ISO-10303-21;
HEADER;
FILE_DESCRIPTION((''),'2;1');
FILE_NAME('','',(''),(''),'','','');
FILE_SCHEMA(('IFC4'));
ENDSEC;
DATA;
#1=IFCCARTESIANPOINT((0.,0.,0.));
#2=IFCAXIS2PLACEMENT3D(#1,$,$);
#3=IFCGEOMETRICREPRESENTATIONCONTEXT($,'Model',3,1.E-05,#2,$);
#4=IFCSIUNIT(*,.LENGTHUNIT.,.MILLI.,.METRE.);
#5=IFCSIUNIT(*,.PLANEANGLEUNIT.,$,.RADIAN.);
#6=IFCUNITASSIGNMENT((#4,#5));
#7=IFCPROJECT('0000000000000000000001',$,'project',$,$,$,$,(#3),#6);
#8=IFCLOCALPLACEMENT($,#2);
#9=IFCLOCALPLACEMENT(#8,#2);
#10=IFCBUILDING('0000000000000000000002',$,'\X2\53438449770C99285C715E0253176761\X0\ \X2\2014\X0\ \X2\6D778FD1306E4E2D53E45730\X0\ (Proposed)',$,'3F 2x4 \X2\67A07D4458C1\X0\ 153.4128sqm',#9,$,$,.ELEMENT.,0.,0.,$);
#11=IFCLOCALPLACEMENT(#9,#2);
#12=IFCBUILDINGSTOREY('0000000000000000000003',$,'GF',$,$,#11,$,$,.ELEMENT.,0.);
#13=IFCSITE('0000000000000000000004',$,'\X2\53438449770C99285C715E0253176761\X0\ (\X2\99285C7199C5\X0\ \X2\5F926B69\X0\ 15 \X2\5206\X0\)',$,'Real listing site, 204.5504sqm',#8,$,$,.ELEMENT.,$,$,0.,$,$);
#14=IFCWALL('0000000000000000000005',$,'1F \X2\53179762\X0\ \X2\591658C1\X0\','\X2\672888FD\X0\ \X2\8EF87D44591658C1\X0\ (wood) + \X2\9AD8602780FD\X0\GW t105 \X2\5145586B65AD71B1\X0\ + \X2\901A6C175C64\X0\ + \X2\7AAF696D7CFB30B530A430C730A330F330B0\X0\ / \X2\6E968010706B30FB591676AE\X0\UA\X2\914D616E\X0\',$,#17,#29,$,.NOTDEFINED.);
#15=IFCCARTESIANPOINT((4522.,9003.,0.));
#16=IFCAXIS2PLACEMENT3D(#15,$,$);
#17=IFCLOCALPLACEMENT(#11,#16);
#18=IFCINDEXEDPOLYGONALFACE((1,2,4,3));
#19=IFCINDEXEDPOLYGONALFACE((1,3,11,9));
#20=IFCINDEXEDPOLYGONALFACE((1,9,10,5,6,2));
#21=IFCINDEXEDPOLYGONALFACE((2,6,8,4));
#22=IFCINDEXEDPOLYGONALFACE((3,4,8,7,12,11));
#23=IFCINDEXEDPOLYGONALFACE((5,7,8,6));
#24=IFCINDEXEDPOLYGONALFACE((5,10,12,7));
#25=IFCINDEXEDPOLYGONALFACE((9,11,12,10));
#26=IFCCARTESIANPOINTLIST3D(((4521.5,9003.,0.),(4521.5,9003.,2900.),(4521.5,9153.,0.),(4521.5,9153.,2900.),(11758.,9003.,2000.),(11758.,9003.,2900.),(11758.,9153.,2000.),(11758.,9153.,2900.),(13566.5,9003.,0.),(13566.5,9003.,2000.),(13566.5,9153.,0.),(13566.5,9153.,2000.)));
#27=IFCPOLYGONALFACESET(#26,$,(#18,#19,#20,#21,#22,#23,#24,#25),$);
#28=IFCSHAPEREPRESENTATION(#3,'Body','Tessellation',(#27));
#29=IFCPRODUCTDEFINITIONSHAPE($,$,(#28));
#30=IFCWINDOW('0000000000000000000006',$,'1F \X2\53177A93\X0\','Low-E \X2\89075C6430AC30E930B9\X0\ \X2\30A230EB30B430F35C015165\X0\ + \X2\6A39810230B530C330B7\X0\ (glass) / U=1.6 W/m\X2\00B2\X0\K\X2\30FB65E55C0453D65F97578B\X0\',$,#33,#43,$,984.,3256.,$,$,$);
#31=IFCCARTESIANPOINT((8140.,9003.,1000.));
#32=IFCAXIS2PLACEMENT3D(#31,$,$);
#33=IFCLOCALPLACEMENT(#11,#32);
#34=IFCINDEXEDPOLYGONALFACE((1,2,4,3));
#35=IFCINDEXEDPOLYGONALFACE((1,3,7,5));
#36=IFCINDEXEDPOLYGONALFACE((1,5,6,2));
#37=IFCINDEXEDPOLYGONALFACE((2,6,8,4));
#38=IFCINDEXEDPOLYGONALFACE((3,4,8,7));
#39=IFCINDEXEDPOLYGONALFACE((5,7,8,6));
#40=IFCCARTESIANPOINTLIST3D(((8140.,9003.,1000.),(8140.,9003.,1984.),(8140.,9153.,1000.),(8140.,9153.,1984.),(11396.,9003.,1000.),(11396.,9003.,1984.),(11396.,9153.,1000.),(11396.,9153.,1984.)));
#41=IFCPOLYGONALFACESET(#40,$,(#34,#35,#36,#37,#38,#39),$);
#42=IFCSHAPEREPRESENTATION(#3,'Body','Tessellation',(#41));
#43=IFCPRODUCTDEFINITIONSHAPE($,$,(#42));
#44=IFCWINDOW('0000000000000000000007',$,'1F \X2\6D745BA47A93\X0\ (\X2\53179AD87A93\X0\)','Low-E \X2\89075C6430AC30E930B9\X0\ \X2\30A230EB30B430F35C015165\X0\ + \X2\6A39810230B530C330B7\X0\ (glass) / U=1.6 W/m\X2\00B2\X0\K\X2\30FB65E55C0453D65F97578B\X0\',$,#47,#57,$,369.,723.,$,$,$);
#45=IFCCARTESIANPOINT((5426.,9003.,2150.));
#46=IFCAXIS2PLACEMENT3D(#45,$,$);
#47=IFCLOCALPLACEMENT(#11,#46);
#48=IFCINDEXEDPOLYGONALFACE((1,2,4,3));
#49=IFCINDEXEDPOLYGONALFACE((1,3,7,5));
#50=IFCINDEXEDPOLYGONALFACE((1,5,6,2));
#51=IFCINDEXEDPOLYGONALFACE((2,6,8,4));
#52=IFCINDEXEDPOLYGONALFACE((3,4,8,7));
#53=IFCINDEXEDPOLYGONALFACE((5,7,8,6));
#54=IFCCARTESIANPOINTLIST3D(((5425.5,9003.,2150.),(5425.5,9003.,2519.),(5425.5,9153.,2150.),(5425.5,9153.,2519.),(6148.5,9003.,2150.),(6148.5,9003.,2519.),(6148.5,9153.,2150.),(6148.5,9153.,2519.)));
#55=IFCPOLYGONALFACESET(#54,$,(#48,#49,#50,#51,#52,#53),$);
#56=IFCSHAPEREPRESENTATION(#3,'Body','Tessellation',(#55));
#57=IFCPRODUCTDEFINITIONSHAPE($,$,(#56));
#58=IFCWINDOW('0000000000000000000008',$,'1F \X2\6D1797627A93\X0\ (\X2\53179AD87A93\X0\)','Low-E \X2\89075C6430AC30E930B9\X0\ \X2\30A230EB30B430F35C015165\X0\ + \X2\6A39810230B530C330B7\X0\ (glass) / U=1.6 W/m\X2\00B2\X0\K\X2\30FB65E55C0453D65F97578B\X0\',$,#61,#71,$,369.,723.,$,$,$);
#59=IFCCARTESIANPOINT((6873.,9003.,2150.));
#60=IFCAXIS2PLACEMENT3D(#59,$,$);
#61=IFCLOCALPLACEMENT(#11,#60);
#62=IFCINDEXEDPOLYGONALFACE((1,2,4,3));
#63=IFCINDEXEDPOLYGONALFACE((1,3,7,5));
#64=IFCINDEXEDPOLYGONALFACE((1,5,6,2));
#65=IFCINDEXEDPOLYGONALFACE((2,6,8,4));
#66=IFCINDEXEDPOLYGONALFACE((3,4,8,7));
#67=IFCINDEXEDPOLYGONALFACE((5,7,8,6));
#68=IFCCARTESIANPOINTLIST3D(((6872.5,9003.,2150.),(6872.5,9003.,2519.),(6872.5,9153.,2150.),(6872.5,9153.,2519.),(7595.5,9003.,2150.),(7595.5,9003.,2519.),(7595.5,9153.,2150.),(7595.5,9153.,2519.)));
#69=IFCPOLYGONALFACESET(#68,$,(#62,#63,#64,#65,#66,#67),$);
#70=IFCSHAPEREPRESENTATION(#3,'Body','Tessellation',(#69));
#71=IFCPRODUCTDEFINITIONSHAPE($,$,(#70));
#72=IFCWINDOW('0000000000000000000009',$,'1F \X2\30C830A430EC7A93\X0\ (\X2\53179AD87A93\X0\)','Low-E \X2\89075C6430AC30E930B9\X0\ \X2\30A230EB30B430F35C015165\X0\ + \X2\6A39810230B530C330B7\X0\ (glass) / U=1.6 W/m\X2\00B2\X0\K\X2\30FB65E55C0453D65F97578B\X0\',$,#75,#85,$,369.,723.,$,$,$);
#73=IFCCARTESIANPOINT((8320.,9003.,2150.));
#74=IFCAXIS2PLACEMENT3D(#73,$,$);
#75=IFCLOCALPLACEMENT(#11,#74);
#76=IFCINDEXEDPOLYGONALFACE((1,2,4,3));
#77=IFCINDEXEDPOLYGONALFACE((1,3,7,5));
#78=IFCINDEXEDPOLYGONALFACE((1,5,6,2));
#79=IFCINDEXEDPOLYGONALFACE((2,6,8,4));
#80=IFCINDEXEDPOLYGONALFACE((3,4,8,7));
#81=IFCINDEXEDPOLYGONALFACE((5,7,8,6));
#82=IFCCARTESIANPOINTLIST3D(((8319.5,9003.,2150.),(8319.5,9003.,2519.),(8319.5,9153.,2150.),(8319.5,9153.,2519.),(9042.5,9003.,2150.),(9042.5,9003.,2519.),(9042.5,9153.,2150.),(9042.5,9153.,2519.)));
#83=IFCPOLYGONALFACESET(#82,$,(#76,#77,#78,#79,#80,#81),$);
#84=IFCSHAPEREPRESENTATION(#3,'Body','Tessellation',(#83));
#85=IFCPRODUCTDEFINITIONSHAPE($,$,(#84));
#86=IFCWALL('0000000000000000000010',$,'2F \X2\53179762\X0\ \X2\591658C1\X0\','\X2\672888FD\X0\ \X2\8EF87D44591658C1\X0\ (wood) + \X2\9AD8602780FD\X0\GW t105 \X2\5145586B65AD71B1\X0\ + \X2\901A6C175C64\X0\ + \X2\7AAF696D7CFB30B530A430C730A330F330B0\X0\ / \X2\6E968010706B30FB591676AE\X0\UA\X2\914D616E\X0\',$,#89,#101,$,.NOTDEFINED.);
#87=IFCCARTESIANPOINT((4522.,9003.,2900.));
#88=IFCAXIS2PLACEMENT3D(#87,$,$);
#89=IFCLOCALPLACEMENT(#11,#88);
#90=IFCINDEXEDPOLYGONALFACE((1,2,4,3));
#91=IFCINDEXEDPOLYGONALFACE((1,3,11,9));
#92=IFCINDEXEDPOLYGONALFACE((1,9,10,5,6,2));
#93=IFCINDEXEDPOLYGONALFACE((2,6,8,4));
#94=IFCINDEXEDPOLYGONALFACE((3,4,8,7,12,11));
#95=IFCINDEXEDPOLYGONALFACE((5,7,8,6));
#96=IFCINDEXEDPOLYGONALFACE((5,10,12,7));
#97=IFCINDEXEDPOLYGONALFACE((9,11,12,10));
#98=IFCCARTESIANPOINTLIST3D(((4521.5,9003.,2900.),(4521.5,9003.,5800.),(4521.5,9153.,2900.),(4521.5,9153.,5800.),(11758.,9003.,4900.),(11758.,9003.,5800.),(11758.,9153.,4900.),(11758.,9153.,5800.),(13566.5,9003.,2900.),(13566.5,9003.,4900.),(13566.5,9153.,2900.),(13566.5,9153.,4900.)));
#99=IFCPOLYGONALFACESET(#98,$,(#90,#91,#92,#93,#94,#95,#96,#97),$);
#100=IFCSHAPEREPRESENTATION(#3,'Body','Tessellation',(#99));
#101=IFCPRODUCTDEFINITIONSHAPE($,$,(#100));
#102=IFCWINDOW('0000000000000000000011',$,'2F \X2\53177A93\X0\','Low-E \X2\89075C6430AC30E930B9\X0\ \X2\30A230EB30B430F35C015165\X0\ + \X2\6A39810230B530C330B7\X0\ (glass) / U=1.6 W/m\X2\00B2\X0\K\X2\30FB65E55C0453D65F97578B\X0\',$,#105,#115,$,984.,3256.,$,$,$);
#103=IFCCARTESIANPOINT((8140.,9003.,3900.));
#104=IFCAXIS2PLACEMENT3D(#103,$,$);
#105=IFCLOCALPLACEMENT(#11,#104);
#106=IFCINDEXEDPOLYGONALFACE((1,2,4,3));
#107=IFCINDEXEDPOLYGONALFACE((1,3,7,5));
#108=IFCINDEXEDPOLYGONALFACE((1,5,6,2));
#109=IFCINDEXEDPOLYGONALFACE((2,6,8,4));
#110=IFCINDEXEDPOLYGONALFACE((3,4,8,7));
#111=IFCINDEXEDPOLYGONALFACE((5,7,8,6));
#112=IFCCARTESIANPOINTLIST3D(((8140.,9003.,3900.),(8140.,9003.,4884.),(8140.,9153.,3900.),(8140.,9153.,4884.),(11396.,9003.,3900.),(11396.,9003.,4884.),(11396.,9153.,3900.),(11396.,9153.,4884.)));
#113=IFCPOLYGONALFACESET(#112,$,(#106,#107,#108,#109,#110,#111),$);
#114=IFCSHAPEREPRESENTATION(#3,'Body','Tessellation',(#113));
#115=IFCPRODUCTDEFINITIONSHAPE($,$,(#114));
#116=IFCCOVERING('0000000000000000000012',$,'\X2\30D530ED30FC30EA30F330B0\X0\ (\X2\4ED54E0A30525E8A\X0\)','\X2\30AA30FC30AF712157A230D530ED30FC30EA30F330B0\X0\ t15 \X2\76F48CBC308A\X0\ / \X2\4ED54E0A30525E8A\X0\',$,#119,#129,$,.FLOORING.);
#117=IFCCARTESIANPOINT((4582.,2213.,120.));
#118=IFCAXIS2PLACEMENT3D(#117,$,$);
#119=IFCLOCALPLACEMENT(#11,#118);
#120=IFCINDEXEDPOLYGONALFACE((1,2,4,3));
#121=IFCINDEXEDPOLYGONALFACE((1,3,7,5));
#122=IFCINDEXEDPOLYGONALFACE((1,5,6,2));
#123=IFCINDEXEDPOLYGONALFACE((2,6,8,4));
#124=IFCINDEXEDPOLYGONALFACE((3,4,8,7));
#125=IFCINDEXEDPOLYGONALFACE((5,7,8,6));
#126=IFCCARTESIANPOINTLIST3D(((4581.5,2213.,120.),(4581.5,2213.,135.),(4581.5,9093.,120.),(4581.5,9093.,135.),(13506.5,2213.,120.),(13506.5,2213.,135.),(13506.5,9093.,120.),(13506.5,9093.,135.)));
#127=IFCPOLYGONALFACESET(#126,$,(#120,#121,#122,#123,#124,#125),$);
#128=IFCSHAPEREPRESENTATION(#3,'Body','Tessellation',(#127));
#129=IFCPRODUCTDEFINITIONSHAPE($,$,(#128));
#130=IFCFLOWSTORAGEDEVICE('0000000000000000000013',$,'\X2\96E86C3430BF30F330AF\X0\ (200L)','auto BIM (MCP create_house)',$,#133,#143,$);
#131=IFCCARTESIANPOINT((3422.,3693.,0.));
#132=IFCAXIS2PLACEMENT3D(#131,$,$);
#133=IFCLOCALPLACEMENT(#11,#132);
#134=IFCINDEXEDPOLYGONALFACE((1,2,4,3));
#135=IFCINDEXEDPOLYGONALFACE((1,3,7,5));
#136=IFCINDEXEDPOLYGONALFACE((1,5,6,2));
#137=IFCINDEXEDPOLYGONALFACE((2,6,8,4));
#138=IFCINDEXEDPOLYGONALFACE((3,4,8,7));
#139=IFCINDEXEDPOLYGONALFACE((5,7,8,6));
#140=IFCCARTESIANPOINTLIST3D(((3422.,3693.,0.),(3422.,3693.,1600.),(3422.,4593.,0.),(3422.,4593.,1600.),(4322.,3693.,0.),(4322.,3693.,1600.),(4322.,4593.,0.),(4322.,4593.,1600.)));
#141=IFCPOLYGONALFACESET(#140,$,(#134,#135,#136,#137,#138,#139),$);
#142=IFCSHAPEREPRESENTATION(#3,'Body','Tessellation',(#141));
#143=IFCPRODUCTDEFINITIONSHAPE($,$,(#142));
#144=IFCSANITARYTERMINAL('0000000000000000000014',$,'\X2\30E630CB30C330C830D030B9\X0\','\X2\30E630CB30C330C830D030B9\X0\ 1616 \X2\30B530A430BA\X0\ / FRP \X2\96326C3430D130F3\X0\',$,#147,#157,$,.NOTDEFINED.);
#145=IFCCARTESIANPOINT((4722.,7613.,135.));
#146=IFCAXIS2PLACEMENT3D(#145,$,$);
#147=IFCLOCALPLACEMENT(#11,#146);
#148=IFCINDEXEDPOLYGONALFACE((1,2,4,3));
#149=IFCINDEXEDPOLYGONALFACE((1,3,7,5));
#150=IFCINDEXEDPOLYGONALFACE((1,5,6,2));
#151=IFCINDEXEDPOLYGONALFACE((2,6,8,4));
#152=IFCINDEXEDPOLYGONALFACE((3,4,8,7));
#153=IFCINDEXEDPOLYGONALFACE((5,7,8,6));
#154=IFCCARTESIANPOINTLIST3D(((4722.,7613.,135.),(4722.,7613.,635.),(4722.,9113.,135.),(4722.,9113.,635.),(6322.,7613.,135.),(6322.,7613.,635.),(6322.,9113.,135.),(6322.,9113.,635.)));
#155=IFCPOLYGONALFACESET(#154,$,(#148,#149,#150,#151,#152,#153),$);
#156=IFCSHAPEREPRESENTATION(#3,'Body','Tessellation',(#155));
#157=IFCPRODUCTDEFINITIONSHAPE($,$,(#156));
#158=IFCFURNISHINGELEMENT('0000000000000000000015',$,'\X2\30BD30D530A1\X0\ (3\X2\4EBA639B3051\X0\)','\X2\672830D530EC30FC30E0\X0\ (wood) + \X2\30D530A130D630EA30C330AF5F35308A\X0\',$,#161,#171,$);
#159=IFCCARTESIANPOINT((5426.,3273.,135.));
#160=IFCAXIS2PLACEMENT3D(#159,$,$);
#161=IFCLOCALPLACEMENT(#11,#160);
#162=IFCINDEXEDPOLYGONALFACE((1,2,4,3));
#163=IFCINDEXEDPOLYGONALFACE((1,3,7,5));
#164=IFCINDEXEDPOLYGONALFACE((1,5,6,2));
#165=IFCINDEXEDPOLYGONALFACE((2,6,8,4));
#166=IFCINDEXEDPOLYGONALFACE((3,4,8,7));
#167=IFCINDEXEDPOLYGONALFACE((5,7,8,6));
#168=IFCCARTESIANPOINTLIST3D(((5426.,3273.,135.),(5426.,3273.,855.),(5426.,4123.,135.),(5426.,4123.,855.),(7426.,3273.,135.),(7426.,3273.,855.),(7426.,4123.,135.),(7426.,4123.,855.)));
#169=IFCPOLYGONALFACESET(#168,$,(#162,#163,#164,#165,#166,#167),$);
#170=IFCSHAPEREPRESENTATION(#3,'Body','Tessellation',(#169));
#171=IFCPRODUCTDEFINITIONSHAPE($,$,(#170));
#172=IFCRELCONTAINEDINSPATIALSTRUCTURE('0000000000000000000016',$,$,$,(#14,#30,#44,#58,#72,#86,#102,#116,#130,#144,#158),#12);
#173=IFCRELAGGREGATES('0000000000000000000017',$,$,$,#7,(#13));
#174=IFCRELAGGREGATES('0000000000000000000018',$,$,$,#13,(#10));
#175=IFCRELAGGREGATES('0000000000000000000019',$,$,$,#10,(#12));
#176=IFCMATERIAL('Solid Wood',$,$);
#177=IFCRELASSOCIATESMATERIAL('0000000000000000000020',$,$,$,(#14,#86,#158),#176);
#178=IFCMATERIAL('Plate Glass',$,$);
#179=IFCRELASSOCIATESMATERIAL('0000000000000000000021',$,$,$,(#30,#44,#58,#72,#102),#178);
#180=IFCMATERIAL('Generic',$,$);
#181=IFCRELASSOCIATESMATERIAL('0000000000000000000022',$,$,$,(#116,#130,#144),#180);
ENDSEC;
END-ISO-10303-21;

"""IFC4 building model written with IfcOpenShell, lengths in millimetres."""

from ifc_helpers import new_model, si_unit, frame, frame_2d, origin, place, context, project, spatial, rectangle, extrude, material, element, fill, save


model = new_model("IFC4")

# Units and contexts
model_context = context("Model", 3, precision=1e-05, world=origin())
ifc_project = project(units=[si_unit("LENGTHUNIT", "METRE", prefix="MILLI"), si_unit("PLANEANGLEUNIT", "RADIAN")], contexts=[model_context])

# Site, building, storey
site_placement = place(None, origin())
site = spatial("IfcSite", under=ifc_project, at=site_placement, Name="千葉県館山市北条 (館山駅 徒歩 15 分)", ObjectType="Real listing site, 204.5504sqm", CompositionType="ELEMENT", RefElevation=0.0)
building_placement = place(site_placement, origin())
building = spatial("IfcBuilding", under=site, at=building_placement, Name="千葉県館山市北条 — 海近の中古地 (Proposed)", ObjectType="3F 2x4 枠組壁 153.4128sqm", CompositionType="ELEMENT", ElevationOfRefHeight=0.0, ElevationOfTerrain=0.0)
storey_placement = place(building_placement, origin())
storey = spatial("IfcBuildingStorey", under=building, at=storey_placement, Name="GF", CompositionType="ELEMENT", Elevation=0.0)

# Wall, openings, windows
ifc_material_1 = material(Name="Solid Wood")
wall_1_placement = place(storey_placement, frame((4522.0, 9003.0, 0.0)))
wall_1 = element("IfcWall", 1, at=wall_1_placement, inside=storey, material=ifc_material_1, Name="1F 北面 外壁", Description="木製 軸組外壁 (wood) + 高性能GW t105 充填断熱 + 通気層 + 窯業系サイディング / 準耐火・外皮UA配慮", PredefinedType="NOTDEFINED", context=model_context, shape_type="SweptSolid", body=[
    extrude(rectangle(XDim=9045.0, YDim=150.0, at=frame_2d((4522.0, 75.0))), frame((4522.0, 9003.0, 0.0)), (0.0, 0.0, 1.0), 2900.0),
])
opening_1_placement = place(storey_placement, frame((8140.0, 9003.0, 1000.0)))
opening_1 = element("IfcOpeningElement", 2, at=opening_1_placement, cuts=wall_1, PredefinedType="NOTDEFINED", context=model_context, shape_type="SweptSolid", body=[
    extrude(rectangle(XDim=3256.0, YDim=150.0, at=frame_2d((1628.0, 75.0))), frame((8140.0, 9003.0, 1000.0)), (0.0, 0.0, 1.0), 984.0),
])
opening_2_placement = place(storey_placement, frame((5426.0, 9003.0, 2150.0)))
opening_2 = element("IfcOpeningElement", 3, at=opening_2_placement, cuts=wall_1, PredefinedType="NOTDEFINED", context=model_context, shape_type="SweptSolid", body=[
    extrude(rectangle(XDim=723.0, YDim=150.0, at=frame_2d((361.0, 75.0))), frame((5426.0, 9003.0, 2150.0)), (0.0, 0.0, 1.0), 369.0),
])
opening_3_placement = place(storey_placement, frame((6873.0, 9003.0, 2150.0)))
opening_3 = element("IfcOpeningElement", 4, at=opening_3_placement, cuts=wall_1, PredefinedType="NOTDEFINED", context=model_context, shape_type="SweptSolid", body=[
    extrude(rectangle(XDim=723.0, YDim=150.0, at=frame_2d((361.0, 75.0))), frame((6873.0, 9003.0, 2150.0)), (0.0, 0.0, 1.0), 369.0),
])
opening_4_placement = place(storey_placement, frame((8320.0, 9003.0, 2150.0)))
opening_4 = element("IfcOpeningElement", 5, at=opening_4_placement, cuts=wall_1, PredefinedType="NOTDEFINED", context=model_context, shape_type="SweptSolid", body=[
    extrude(rectangle(XDim=723.0, YDim=150.0, at=frame_2d((361.0, 75.0))), frame((8320.0, 9003.0, 2150.0)), (0.0, 0.0, 1.0), 369.0),
])
ifc_material_2 = material(Name="Plate Glass")
window_1_placement = place(storey_placement, frame((8140.0, 9003.0, 1000.0)))
window_1 = element("IfcWindow", 6, at=window_1_placement, inside=storey, material=ifc_material_2, Name="1F 北窓", Description="Low-E 複層ガラス アルゴン封入 + 樹脂サッシ (glass) / U=1.6 W/m²K・日射取得型", OverallHeight=984.0, OverallWidth=3256.0, context=model_context, shape_type="SweptSolid", body=[
    extrude(rectangle(XDim=3256.0, YDim=150.0, at=frame_2d((1628.0, 75.0))), frame((8140.0, 9003.0, 1000.0)), (0.0, 0.0, 1.0), 984.0),
])
fill(opening_1, window_1)
window_2_placement = place(storey_placement, frame((5426.0, 9003.0, 2150.0)))
window_2 = element("IfcWindow", 7, at=window_2_placement, inside=storey, material=ifc_material_2, Name="1F 浴室窓 (北高窓)", Description="Low-E 複層ガラス アルゴン封入 + 樹脂サッシ (glass) / U=1.6 W/m²K・日射取得型", OverallHeight=369.0, OverallWidth=723.0, context=model_context, shape_type="SweptSolid", body=[
    extrude(rectangle(XDim=723.0, YDim=150.0, at=frame_2d((361.0, 75.0))), frame((5426.0, 9003.0, 2150.0)), (0.0, 0.0, 1.0), 369.0),
])
fill(opening_2, window_2)
window_3_placement = place(storey_placement, frame((6873.0, 9003.0, 2150.0)))
window_3 = element("IfcWindow", 8, at=window_3_placement, inside=storey, material=ifc_material_2, Name="1F 洗面窓 (北高窓)", Description="Low-E 複層ガラス アルゴン封入 + 樹脂サッシ (glass) / U=1.6 W/m²K・日射取得型", OverallHeight=369.0, OverallWidth=723.0, context=model_context, shape_type="SweptSolid", body=[
    extrude(rectangle(XDim=723.0, YDim=150.0, at=frame_2d((361.0, 75.0))), frame((6873.0, 9003.0, 2150.0)), (0.0, 0.0, 1.0), 369.0),
])
fill(opening_3, window_3)
window_4_placement = place(storey_placement, frame((8320.0, 9003.0, 2150.0)))
window_4 = element("IfcWindow", 9, at=window_4_placement, inside=storey, material=ifc_material_2, Name="1F トイレ窓 (北高窓)", Description="Low-E 複層ガラス アルゴン封入 + 樹脂サッシ (glass) / U=1.6 W/m²K・日射取得型", OverallHeight=369.0, OverallWidth=723.0, context=model_context, shape_type="SweptSolid", body=[
    extrude(rectangle(XDim=723.0, YDim=150.0, at=frame_2d((361.0, 75.0))), frame((8320.0, 9003.0, 2150.0)), (0.0, 0.0, 1.0), 369.0),
])
fill(opening_4, window_4)

# Wall, opening, window
wall_2_placement = place(storey_placement, frame((4522.0, 9003.0, 2900.0)))
wall_2 = element("IfcWall", 10, at=wall_2_placement, inside=storey, material=ifc_material_1, Name="2F 北面 外壁", Description="木製 軸組外壁 (wood) + 高性能GW t105 充填断熱 + 通気層 + 窯業系サイディング / 準耐火・外皮UA配慮", PredefinedType="NOTDEFINED", context=model_context, shape_type="SweptSolid", body=[
    extrude(rectangle(XDim=9045.0, YDim=150.0, at=frame_2d((4522.0, 75.0))), frame((4522.0, 9003.0, 2900.0)), (0.0, 0.0, 1.0), 2900.0),
])
opening_5_placement = place(storey_placement, frame((8140.0, 9003.0, 3900.0)))
opening_5 = element("IfcOpeningElement", 11, at=opening_5_placement, cuts=wall_2, PredefinedType="NOTDEFINED", context=model_context, shape_type="SweptSolid", body=[
    extrude(rectangle(XDim=3256.0, YDim=150.0, at=frame_2d((1628.0, 75.0))), frame((8140.0, 9003.0, 3900.0)), (0.0, 0.0, 1.0), 984.0),
])
window_5_placement = place(storey_placement, frame((8140.0, 9003.0, 3900.0)))
window_5 = element("IfcWindow", 12, at=window_5_placement, inside=storey, material=ifc_material_2, Name="2F 北窓", Description="Low-E 複層ガラス アルゴン封入 + 樹脂サッシ (glass) / U=1.6 W/m²K・日射取得型", OverallHeight=984.0, OverallWidth=3256.0, context=model_context, shape_type="SweptSolid", body=[
    extrude(rectangle(XDim=3256.0, YDim=150.0, at=frame_2d((1628.0, 75.0))), frame((8140.0, 9003.0, 3900.0)), (0.0, 0.0, 1.0), 984.0),
])
fill(opening_5, window_5)

# Covering
ifc_material_3 = material(Name="Generic")
covering_placement = place(storey_placement, frame((4582.0, 2213.0, 120.0)))
element("IfcCovering", 13, at=covering_placement, inside=storey, material=ifc_material_3, Name="フローリング (仕上げ床)", Description="オーク無垢フローリング t15 直貼り / 仕上げ床", PredefinedType="FLOORING", context=model_context, shape_type="SweptSolid", body=[
    extrude(rectangle(XDim=8925.0, YDim=6880.0, at=frame_2d((4462.0, 3440.0))), frame((4582.0, 2213.0, 120.0)), (0.0, 0.0, 1.0), 15.0),
])

# Flow storage device
flow_storage_device_placement = place(storey_placement, frame((3422.0, 3693.0, 0.0)))
element("IfcFlowStorageDevice", 14, at=flow_storage_device_placement, inside=storey, material=ifc_material_3, Name="雨水タンク (200L)", Description="auto BIM (MCP create_house)", context=model_context, shape_type="SweptSolid", body=[
    extrude(rectangle(XDim=900.0, YDim=900.0, at=frame_2d((450.0, 450.0))), frame((3422.0, 3693.0, 0.0)), (0.0, 0.0, 1.0), 1600.0),
])

# Sanitary terminal
sanitary_terminal_placement = place(storey_placement, frame((4722.0, 7613.0, 135.0)))
element("IfcSanitaryTerminal", 15, at=sanitary_terminal_placement, inside=storey, material=ifc_material_3, Name="ユニットバス", Description="ユニットバス 1616 サイズ / FRP 防水パン", PredefinedType="NOTDEFINED", context=model_context, shape_type="SweptSolid", body=[
    extrude(rectangle(XDim=1600.0, YDim=1500.0, at=frame_2d((800.0, 750.0))), frame((4722.0, 7613.0, 135.0)), (0.0, 0.0, 1.0), 500.0),
])

# Furnishing element
furnishing_placement = place(storey_placement, frame((5426.0, 3273.0, 135.0)))
element("IfcFurnishingElement", 16, at=furnishing_placement, inside=storey, material=ifc_material_1, Name="ソファ (3人掛け)", Description="木フレーム (wood) + ファブリック張り", context=model_context, shape_type="SweptSolid", body=[
    extrude(rectangle(XDim=2000.0, YDim=850.0, at=frame_2d((1000.0, 425.0))), frame((5426.0, 3273.0, 135.0)), (0.0, 0.0, 1.0), 720.0),
])

save(model, "model.ifc")
